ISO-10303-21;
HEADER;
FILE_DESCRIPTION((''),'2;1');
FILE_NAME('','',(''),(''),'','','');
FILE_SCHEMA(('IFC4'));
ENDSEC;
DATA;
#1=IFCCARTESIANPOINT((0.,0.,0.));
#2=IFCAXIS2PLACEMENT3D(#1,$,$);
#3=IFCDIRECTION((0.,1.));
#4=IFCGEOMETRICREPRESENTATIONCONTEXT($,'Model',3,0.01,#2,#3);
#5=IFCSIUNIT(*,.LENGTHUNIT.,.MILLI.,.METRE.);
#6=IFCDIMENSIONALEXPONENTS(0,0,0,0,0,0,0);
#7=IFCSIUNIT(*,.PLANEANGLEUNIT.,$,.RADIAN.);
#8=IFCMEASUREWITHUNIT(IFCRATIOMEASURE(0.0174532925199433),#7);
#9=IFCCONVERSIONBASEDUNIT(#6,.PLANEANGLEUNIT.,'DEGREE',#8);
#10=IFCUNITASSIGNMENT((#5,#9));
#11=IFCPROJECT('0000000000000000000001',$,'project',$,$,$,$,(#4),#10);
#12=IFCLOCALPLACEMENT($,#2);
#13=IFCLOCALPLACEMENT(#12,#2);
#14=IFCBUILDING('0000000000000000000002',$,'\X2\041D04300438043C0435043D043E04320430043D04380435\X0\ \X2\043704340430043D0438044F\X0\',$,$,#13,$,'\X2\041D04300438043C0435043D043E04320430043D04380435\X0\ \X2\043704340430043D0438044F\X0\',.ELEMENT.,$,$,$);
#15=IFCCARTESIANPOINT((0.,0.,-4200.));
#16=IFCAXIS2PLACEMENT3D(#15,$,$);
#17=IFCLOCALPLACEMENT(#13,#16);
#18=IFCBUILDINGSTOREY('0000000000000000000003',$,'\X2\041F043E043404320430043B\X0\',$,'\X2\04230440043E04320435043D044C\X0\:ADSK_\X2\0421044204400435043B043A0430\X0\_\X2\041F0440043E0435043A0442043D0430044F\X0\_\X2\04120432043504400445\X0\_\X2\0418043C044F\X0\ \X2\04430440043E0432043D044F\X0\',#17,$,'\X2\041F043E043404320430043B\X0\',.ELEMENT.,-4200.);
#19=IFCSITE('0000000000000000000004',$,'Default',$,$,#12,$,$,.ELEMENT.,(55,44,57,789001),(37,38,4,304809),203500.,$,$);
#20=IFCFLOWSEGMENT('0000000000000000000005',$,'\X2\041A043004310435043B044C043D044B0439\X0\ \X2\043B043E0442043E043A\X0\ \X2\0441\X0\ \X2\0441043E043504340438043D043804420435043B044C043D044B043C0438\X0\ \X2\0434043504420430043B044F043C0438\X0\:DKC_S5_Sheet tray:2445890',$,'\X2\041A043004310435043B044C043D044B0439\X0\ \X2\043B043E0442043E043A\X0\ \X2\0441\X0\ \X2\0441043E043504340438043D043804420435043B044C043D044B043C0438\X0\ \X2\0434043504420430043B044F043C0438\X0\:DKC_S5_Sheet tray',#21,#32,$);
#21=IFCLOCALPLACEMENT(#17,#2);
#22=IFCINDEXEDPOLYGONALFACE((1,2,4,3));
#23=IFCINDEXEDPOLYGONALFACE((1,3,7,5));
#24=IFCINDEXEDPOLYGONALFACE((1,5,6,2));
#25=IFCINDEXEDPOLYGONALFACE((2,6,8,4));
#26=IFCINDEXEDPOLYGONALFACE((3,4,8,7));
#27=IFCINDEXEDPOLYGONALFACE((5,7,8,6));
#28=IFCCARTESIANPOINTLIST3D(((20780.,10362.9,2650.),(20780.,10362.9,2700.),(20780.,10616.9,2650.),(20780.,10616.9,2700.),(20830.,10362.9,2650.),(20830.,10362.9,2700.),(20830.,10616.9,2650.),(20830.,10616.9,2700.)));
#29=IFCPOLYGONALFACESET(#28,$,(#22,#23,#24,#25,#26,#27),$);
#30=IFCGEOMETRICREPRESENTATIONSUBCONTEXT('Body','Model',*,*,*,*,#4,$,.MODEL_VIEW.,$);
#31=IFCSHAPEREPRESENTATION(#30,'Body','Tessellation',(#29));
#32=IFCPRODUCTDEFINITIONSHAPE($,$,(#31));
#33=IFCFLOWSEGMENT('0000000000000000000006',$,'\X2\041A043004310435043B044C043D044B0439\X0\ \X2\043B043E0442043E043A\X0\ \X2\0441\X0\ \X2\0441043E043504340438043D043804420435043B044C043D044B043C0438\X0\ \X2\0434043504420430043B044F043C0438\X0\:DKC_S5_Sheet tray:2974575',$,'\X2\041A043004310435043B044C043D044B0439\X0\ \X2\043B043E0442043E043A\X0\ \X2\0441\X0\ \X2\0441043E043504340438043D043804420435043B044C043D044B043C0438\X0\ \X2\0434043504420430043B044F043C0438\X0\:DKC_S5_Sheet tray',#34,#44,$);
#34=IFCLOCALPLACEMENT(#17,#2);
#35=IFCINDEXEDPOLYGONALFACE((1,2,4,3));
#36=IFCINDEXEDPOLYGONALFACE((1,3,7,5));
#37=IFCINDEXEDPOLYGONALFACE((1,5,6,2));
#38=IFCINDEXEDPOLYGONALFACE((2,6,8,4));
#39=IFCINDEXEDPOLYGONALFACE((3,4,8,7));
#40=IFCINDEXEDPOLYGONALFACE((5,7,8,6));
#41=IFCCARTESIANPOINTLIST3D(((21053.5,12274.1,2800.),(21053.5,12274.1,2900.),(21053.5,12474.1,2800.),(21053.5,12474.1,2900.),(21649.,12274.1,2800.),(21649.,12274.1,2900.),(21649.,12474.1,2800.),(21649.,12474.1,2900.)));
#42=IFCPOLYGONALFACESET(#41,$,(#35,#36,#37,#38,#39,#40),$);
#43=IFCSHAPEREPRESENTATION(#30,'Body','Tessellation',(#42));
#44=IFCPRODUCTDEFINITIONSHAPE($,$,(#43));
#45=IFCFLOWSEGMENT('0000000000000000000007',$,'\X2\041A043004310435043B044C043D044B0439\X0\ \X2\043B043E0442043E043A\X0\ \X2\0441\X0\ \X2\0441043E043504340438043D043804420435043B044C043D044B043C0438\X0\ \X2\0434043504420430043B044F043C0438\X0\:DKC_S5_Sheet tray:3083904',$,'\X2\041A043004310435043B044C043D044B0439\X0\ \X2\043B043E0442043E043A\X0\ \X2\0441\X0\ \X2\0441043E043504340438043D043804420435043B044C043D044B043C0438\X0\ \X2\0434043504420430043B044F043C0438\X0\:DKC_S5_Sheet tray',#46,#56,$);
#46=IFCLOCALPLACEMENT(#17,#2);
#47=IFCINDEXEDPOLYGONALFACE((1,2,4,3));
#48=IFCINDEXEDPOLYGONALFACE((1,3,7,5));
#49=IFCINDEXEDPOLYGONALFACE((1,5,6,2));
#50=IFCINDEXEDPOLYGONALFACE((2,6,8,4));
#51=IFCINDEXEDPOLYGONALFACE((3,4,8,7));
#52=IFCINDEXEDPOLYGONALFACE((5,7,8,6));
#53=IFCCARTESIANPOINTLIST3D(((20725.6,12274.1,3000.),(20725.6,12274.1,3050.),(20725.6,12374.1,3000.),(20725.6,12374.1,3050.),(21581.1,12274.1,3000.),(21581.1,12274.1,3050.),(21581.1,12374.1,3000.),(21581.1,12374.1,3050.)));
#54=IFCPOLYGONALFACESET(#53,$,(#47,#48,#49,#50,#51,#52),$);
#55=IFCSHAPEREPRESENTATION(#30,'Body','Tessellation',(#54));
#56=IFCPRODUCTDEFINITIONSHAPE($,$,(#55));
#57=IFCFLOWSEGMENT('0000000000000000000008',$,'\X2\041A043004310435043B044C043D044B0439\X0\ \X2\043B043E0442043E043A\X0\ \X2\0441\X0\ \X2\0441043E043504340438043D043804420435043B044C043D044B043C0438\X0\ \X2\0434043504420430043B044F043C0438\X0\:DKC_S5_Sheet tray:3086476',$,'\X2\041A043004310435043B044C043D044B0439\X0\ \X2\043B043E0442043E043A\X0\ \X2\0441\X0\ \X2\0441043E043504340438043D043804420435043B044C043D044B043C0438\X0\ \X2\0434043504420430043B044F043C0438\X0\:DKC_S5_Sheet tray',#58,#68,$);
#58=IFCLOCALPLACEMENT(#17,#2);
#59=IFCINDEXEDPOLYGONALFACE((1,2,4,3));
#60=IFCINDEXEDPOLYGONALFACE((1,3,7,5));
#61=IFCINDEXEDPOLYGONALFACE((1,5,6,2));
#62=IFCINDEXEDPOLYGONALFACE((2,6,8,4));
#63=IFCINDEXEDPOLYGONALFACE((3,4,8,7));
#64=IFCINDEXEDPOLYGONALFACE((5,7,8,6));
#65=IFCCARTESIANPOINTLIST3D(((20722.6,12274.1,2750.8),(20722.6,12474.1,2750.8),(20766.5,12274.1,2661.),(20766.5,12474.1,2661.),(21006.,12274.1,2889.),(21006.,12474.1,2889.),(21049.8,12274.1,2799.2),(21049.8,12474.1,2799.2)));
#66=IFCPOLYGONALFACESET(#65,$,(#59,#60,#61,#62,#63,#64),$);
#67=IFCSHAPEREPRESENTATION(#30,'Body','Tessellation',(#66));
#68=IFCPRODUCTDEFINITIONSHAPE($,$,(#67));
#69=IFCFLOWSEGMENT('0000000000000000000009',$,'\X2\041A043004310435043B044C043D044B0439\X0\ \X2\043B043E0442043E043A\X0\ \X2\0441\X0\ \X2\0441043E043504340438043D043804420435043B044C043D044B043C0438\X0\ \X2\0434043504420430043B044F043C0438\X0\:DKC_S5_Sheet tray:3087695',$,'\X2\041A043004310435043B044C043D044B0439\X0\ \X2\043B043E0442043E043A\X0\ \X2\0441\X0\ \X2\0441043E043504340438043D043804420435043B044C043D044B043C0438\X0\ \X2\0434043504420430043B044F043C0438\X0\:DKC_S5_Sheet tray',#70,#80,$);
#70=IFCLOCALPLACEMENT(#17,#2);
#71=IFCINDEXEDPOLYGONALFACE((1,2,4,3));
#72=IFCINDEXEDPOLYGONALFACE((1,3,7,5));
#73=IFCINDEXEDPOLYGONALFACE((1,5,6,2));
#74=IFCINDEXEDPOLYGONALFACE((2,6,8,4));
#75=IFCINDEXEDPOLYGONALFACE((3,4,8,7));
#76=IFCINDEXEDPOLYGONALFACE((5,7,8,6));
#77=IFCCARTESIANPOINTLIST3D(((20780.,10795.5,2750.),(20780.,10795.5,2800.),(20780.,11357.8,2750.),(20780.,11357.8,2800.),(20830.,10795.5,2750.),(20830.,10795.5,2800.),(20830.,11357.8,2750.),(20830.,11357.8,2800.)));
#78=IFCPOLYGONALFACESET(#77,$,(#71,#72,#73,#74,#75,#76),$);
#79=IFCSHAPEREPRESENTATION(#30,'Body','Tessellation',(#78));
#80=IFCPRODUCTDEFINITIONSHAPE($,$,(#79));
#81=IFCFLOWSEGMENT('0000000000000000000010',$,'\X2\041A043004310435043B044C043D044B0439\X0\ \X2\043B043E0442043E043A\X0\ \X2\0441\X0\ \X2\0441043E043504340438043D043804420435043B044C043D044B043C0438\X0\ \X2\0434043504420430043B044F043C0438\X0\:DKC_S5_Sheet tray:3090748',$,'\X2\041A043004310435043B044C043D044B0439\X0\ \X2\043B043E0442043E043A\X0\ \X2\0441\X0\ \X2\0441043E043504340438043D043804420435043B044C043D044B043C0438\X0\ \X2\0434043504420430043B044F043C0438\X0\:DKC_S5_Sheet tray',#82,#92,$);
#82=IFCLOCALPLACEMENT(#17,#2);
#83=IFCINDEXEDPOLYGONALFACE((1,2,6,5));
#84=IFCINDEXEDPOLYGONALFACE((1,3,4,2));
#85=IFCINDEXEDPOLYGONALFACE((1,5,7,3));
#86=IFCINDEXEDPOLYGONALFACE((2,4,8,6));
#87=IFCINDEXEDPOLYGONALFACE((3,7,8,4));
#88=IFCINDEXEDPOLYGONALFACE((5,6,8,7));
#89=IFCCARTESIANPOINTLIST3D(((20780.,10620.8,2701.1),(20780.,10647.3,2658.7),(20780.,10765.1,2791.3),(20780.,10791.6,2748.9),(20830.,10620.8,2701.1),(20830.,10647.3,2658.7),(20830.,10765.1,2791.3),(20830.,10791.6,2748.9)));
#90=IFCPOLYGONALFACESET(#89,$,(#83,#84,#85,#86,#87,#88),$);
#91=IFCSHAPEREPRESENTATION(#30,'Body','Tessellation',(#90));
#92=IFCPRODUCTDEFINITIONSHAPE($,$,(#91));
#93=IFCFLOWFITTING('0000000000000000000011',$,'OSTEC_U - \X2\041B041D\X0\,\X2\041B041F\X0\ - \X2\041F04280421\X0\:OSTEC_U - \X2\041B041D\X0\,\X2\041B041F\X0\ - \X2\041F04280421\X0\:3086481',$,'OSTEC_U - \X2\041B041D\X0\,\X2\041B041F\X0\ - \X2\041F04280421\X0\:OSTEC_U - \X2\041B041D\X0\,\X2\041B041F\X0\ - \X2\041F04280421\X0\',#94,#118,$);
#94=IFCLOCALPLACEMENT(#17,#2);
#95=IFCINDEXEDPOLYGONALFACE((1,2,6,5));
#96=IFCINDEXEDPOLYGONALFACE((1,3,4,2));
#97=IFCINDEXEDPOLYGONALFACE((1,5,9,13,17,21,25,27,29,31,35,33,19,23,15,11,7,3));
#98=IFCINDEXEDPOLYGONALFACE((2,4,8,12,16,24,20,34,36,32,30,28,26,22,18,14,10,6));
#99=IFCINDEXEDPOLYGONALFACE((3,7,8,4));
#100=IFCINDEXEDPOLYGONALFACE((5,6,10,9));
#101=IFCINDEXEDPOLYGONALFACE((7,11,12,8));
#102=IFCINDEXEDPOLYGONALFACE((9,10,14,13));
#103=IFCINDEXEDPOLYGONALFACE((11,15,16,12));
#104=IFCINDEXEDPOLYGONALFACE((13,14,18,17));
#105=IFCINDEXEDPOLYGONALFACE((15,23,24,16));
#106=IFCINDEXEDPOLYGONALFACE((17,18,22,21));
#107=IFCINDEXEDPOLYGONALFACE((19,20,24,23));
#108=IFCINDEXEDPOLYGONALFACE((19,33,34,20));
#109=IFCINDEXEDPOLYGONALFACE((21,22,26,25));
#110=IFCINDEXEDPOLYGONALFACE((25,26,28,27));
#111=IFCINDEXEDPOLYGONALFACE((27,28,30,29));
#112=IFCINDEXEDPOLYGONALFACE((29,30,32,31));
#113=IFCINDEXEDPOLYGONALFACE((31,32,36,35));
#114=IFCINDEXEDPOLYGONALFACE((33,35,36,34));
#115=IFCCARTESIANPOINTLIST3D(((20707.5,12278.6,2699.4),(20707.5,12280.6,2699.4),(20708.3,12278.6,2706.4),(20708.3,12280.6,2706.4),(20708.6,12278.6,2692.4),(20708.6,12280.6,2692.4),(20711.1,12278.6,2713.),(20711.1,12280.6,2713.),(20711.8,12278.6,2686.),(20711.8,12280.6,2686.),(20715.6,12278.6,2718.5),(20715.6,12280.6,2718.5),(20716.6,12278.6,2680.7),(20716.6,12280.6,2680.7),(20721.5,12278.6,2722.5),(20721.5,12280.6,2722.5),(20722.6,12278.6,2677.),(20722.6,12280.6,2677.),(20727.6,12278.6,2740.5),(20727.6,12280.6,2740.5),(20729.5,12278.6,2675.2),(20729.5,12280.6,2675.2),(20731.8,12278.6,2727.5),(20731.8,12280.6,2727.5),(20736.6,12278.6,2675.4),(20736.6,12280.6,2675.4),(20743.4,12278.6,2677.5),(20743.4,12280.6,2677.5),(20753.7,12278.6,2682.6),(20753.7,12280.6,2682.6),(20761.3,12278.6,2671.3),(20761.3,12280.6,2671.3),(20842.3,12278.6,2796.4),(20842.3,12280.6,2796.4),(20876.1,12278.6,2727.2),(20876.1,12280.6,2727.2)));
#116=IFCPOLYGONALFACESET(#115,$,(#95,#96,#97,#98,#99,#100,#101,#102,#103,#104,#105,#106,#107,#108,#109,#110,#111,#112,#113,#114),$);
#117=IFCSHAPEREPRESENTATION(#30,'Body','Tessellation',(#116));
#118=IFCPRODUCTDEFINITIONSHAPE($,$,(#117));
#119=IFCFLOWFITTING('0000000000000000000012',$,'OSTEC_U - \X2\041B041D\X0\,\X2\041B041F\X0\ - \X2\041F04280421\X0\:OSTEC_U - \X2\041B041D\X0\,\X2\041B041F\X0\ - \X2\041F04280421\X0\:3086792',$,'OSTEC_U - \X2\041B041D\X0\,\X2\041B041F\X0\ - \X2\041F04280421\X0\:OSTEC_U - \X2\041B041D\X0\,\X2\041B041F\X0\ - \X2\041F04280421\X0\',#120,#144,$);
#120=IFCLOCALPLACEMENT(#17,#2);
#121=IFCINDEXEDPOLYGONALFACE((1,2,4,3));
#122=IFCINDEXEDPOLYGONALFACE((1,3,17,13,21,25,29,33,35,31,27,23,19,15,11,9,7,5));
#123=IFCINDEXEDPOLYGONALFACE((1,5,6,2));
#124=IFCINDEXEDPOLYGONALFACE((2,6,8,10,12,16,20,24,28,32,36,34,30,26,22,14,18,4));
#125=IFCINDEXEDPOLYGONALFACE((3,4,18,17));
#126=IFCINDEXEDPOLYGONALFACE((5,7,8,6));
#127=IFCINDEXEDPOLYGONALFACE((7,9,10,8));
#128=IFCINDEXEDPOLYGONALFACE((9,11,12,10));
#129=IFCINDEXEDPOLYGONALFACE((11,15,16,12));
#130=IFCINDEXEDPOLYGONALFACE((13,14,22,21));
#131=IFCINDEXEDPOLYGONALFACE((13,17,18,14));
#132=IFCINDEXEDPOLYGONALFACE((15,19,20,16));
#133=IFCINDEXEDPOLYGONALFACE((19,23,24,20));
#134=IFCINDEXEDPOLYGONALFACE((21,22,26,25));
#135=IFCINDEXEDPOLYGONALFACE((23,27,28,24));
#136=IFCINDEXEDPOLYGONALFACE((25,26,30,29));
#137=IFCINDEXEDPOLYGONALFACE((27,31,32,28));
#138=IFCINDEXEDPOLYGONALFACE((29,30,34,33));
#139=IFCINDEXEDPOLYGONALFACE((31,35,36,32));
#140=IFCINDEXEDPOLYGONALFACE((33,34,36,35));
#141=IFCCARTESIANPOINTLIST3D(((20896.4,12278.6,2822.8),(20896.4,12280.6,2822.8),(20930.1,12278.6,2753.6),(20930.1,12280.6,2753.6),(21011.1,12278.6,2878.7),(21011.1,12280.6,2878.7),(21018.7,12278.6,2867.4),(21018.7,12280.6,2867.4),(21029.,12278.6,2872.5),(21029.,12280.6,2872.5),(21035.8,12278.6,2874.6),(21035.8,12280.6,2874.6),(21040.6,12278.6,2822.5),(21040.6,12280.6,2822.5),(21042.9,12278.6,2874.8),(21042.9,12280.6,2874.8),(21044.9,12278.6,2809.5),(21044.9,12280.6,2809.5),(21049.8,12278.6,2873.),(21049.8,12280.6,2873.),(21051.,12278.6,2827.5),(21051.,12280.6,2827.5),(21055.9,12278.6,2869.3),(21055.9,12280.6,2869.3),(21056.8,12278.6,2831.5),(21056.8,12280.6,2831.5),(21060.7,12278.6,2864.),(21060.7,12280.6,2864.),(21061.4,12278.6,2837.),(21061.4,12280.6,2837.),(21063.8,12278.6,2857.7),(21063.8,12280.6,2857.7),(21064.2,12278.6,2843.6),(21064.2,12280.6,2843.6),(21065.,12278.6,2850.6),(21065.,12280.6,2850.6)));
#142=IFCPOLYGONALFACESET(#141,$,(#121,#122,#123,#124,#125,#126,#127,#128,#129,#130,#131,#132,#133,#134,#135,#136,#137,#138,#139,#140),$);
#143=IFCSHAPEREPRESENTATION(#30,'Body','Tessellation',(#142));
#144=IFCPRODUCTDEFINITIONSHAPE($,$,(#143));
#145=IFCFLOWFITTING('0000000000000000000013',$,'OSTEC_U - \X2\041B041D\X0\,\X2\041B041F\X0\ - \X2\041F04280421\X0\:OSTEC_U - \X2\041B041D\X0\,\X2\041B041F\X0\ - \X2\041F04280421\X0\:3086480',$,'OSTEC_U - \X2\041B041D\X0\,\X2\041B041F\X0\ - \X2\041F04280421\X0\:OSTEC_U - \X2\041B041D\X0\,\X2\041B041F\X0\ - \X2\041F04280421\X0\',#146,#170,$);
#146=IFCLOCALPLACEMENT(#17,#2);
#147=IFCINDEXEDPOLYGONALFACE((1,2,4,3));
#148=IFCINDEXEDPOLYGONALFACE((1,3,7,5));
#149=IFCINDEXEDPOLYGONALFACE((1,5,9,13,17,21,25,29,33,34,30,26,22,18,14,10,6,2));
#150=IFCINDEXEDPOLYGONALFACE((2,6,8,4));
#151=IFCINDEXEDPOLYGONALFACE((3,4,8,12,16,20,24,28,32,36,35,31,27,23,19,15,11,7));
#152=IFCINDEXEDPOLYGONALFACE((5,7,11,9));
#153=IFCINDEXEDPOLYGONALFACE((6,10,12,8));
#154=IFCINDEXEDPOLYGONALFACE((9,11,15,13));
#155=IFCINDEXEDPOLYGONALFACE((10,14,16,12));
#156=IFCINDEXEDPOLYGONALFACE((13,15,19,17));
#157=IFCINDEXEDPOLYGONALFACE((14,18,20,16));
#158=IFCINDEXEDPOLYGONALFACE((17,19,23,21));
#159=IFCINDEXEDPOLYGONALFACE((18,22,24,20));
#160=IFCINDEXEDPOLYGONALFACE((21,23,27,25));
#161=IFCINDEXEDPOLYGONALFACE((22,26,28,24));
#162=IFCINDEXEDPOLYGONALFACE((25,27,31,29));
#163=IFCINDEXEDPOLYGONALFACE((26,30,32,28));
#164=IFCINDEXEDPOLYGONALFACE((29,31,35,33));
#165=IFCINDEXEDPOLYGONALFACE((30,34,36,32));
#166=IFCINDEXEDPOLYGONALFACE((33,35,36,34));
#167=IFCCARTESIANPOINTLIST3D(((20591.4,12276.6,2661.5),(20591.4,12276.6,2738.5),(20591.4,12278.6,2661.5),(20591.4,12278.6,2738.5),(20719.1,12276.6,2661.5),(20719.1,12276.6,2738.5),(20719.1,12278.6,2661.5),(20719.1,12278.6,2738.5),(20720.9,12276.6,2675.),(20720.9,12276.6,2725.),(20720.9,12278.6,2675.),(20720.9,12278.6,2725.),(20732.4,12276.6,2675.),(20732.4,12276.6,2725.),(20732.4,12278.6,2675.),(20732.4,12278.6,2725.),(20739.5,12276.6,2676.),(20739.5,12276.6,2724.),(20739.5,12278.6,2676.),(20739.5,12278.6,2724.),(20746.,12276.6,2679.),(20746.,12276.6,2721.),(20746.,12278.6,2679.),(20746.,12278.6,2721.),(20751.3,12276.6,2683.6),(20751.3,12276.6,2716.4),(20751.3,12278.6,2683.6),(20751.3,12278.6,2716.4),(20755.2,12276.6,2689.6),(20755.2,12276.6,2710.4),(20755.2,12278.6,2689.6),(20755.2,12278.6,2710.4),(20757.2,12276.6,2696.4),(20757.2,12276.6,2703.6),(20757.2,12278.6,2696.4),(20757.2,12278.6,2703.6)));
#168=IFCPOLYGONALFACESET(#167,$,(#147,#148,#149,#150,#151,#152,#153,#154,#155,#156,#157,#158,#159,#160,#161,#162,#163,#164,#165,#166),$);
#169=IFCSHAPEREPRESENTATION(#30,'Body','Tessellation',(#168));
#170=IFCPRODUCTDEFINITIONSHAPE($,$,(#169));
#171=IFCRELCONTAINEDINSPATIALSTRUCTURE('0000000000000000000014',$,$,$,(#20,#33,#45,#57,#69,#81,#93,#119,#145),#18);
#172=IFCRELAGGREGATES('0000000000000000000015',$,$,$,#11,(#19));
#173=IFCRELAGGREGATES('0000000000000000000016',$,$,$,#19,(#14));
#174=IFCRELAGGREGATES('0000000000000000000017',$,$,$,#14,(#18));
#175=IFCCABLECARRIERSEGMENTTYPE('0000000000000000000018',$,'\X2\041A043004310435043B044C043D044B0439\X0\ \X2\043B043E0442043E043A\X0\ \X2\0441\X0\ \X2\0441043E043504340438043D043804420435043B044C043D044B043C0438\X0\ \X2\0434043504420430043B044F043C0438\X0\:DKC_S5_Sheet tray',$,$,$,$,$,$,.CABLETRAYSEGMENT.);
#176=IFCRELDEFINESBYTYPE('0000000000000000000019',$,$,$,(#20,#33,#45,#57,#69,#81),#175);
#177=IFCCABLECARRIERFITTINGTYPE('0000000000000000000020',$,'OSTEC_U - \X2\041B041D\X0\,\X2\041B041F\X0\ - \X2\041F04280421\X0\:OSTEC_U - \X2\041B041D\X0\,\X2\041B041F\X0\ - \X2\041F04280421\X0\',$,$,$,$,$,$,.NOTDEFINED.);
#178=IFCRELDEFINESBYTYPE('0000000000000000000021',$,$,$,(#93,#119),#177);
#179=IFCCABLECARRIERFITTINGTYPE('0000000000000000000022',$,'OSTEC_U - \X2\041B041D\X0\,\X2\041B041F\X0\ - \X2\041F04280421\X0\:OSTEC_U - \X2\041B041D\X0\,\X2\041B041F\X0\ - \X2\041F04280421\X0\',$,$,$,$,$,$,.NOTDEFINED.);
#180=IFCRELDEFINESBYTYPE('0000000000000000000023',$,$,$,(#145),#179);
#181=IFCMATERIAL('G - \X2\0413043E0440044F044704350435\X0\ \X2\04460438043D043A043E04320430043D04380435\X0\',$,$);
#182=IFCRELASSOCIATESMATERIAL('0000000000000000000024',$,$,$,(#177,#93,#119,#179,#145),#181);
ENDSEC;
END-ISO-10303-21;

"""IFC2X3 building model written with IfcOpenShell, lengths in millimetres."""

from ifc_helpers import new_model, entity, si_unit, converted_unit, direction, frame, frame_2d, origin, origin_2d_with_axis, place, context, subcontext, project, spatial, polyline, circle_curve, parameter, trimmed, segment, composite_curve, rectangle, outline, extrude, source, transform, mapped, material, type_object, type_shapes, element, save


model = new_model("IFC2X3")

# Units and contexts
model_context = context("Model", 3, precision=0.01, world=origin(), true_north=direction((0.0, 1.0)))
body_context = subcontext(model_context, "Body", "Model", "MODEL_VIEW")
ifc_project = project(units=[si_unit("LENGTHUNIT", "METRE", prefix="MILLI"), converted_unit("PLANEANGLEUNIT", "DEGREE", entity("IfcRatioMeasure", 0.0174532925199433), si_unit("PLANEANGLEUNIT", "RADIAN"), dimensions=[0, 0, 0, 0, 0, 0, 0])], contexts=[model_context])

# Site, building, storey
site_placement = place(None, origin())
site = spatial("IfcSite", under=ifc_project, at=site_placement, Name="Default", CompositionType="ELEMENT", RefLatitude=(55, 44, 57, 789001), RefLongitude=(37, 38, 4, 304809), RefElevation=203500.0)
building_placement = place(site_placement, origin())
building = spatial("IfcBuilding", under=site, at=building_placement, Name="Наименование здания", LongName="Наименование здания", CompositionType="ELEMENT")
storey_placement = place(building_placement, frame((0.0, 0.0, -4200.0)))
storey = spatial("IfcBuildingStorey", under=building, at=storey_placement, Name="Подвал", ObjectType="Уровень:ADSK_Стрелка_Проектная_Вверх_Имя уровня", LongName="Подвал", CompositionType="ELEMENT", Elevation=-4200.0)

# Flow segments
cable_carrier_segment_type = type_object("IfcCableCarrierSegmentType", Name="Кабельный лоток с соединительными деталями:DKC_S5_Sheet tray", PredefinedType="CABLETRAYSEGMENT")
flow_segment_1_placement = place(storey_placement, frame((20780.0, 10362.9, 2650.0)))
element("IfcFlowSegment", 1, at=flow_segment_1_placement, inside=storey, type_object=cable_carrier_segment_type, Name="Кабельный лоток с соединительными деталями:DKC_S5_Sheet tray:2445890", ObjectType="Кабельный лоток с соединительными деталями:DKC_S5_Sheet tray", context=body_context, shape_type="SweptSolid", body=[
    extrude(rectangle(XDim=254.0, YDim=50.0, at=origin_2d_with_axis()), frame((25.0, 127.0, 0.0), z_axis=(0.0, 0.0, 1.0), x_axis=(0.0, 1.0, 0.0)), (0.0, 0.0, 1.0), 50.0),
])
flow_segment_2_placement = place(storey_placement, frame((21053.5, 12274.1, 2800.0)))
element("IfcFlowSegment", 2, at=flow_segment_2_placement, inside=storey, type_object=cable_carrier_segment_type, Name="Кабельный лоток с соединительными деталями:DKC_S5_Sheet tray:2974575", ObjectType="Кабельный лоток с соединительными деталями:DKC_S5_Sheet tray", context=body_context, shape_type="SweptSolid", body=[
    extrude(rectangle(XDim=595.5, YDim=200.0, at=origin_2d_with_axis()), frame((297.8, 100.0, 0.0), z_axis=(-0.000053, 0.000015, 1.0), x_axis=(-1.0, 0.0, -0.000053)), (0.0, 0.0, 1.0), 100.0),
])
flow_segment_3_placement = place(storey_placement, frame((20725.6, 12274.1, 3000.0)))
element("IfcFlowSegment", 3, at=flow_segment_3_placement, inside=storey, type_object=cable_carrier_segment_type, Name="Кабельный лоток с соединительными деталями:DKC_S5_Sheet tray:3083904", ObjectType="Кабельный лоток с соединительными деталями:DKC_S5_Sheet tray", context=body_context, shape_type="SweptSolid", body=[
    extrude(rectangle(XDim=855.6, YDim=100.0, at=origin_2d_with_axis()), frame((427.8, 50.0, 0.0), z_axis=(0.0, 0.0, 1.0), x_axis=(-1.0, 0.0, 0.0)), (0.0, 0.0, 1.0), 50.0),
])
flow_segment_4_placement = place(storey_placement, frame((20722.6, 12274.1, 2661.0)))
element("IfcFlowSegment", 4, at=flow_segment_4_placement, inside=storey, type_object=cable_carrier_segment_type, Name="Кабельный лоток с соединительными деталями:DKC_S5_Sheet tray:3086476", ObjectType="Кабельный лоток с соединительными деталями:DKC_S5_Sheet tray", context=body_context, shape_type="SweptSolid", body=[
    extrude(rectangle(XDim=100.0, YDim=200.0, at=origin_2d_with_axis()), frame((21.9, 100.0, 44.9), z_axis=(0.898793, 0.0, 0.438374), x_axis=(-0.438374, 0.0, 0.898793)), (0.0, 0.0, 1.0), 315.2),
])
flow_segment_5_placement = place(storey_placement, frame((20780.0, 10795.5, 2750.0)))
element("IfcFlowSegment", 5, at=flow_segment_5_placement, inside=storey, type_object=cable_carrier_segment_type, Name="Кабельный лоток с соединительными деталями:DKC_S5_Sheet tray:3087695", ObjectType="Кабельный лоток с соединительными деталями:DKC_S5_Sheet tray", context=body_context, shape_type="SweptSolid", body=[
    extrude(rectangle(XDim=562.3, YDim=50.0, at=origin_2d_with_axis()), frame((25.0, 281.2, 0.0), z_axis=(0.0, 0.0, 1.0), x_axis=(0.0, -1.0, 0.0)), (0.0, 0.0, 1.0), 50.0),
])
flow_segment_6_placement = place(storey_placement, frame((20780.0, 10620.8, 2658.7)))
element("IfcFlowSegment", 6, at=flow_segment_6_placement, inside=storey, type_object=cable_carrier_segment_type, Name="Кабельный лоток с соединительными деталями:DKC_S5_Sheet tray:3090748", ObjectType="Кабельный лоток с соединительными деталями:DKC_S5_Sheet tray", context=body_context, shape_type="SweptSolid", body=[
    extrude(rectangle(XDim=50.0, YDim=50.0, at=frame_2d((0.0, 0.0), x_axis=(0.0, 1.0))), frame((25.0, 13.2, 21.2), z_axis=(0.0, 0.848048, 0.529919), x_axis=(-1.0, 0.0, 0.0)), (0.0, 0.0, 1.0), 170.1),
])

# Flow fittings
ifc_material_1 = material(Name="G - Горячее цинкование")
cable_carrier_fitting_type_1 = type_object("IfcCableCarrierFittingType", Name="OSTEC_U - ЛН,ЛП - ПШС:OSTEC_U - ЛН,ЛП - ПШС", PredefinedType="NOTDEFINED", material=ifc_material_1)
shared_shape_1 = source(origin(), body_context, "Body", "SweptSolid", [
    extrude(outline(composite_curve([segment(trimmed(circle_curve(frame_2d((-41.5, 0.0), x_axis=(1.0, 0.0)), 25.0), [parameter(90.0)], [parameter(270.0)], True, "PARAMETER"), True, "CONTINUOUS"), segment(polyline([(-41.5, -25.0), (-30.0, -25.0)]), True, "CONTINUOUS"), segment(polyline([(-30.0, -25.0), (-28.1, -38.5)]), True, "CONTINUOUS"), segment(polyline([(-28.1, -38.5), (99.5, -38.5)]), True, "CONTINUOUS"), segment(polyline([(99.5, -38.5), (99.5, 38.5)]), True, "CONTINUOUS"), segment(polyline([(99.5, 38.5), (-28.1, 38.5)]), True, "CONTINUOUS"), segment(polyline([(-28.1, 38.5), (-30.0, 25.0)]), True, "CONTINUOUS"), segment(polyline([(-30.0, 25.0), (-41.5, 25.0)]), True, "CONTINUOUS")], self_intersect=False)), frame((41.5, 0.0, 0.0), z_axis=(0.0, 0.0, -1.0), x_axis=(1.0, 0.0, 0.0)), (0.0, 0.0, -1.0), 2.0),
])
type_shapes(cable_carrier_fitting_type_1, [shared_shape_1])
for number, where, z_axis, x_axis, name in (
    (7, (20732.5, 12280.6, 2700.0), (0.0, -1.0, 0.0), (0.898794, 0.0, 0.438371), "OSTEC_U - ЛН,ЛП - ПШС:OSTEC_U - ЛН,ЛП - ПШС:3086481"),
    (8, (21040.0, 12280.6, 2850.0), (0.0, -1.0, 0.0), (-0.898793, 0.0, -0.438374), "OSTEC_U - ЛН,ЛП - ПШС:OSTEC_U - ЛН,ЛП - ПШС:3086792"),
):
    element("IfcFlowFitting", number, at=place(storey_placement, frame(where, z_axis=z_axis, x_axis=x_axis)), inside=storey, type_object=cable_carrier_fitting_type_1, material=ifc_material_1, Name=name, ObjectType="OSTEC_U - ЛН,ЛП - ПШС:OSTEC_U - ЛН,ЛП - ПШС", context=body_context, shape_type="MappedRepresentation", body=[
        mapped(shared_shape_1, transform((0.0, 0.0, 0.0), scale=1.0)),
    ])
cable_carrier_fitting_type_2 = type_object("IfcCableCarrierFittingType", Name="OSTEC_U - ЛН,ЛП - ПШС:OSTEC_U - ЛН,ЛП - ПШС", PredefinedType="NOTDEFINED", material=ifc_material_1)
shared_shape_2 = source(origin(), body_context, "Body", "SweptSolid", [
    extrude(outline(composite_curve([segment(trimmed(circle_curve(frame_2d((-41.5, 0.0), x_axis=(1.0, 0.0)), 25.0), [parameter(90.0)], [parameter(270.0)], True, "PARAMETER"), True, "CONTINUOUS"), segment(polyline([(-41.5, -25.0), (-30.0, -25.0)]), True, "CONTINUOUS"), segment(polyline([(-30.0, -25.0), (-28.1, -38.5)]), True, "CONTINUOUS"), segment(polyline([(-28.1, -38.5), (99.5, -38.5)]), True, "CONTINUOUS"), segment(polyline([(99.5, -38.5), (99.5, 38.5)]), True, "CONTINUOUS"), segment(polyline([(99.5, 38.5), (-28.1, 38.5)]), True, "CONTINUOUS"), segment(polyline([(-28.1, 38.5), (-30.0, 25.0)]), True, "CONTINUOUS"), segment(polyline([(-30.0, 25.0), (-41.5, 25.0)]), True, "CONTINUOUS")], self_intersect=False)), frame((41.5, 0.0, 0.0)), (0.0, 0.0, 1.0), 2.0),
])
type_shapes(cable_carrier_fitting_type_2, [shared_shape_2])
for number, where, z_axis, x_axis, name in (
    (9, (20732.5, 12278.6, 2700.0), (0.0, -1.0, 0.0), (-1.0, 0.0, 0.0), "OSTEC_U - ЛН,ЛП - ПШС:OSTEC_U - ЛН,ЛП - ПШС:3086480"),
):
    element("IfcFlowFitting", number, at=place(storey_placement, frame(where, z_axis=z_axis, x_axis=x_axis)), inside=storey, type_object=cable_carrier_fitting_type_2, material=ifc_material_1, Name=name, ObjectType="OSTEC_U - ЛН,ЛП - ПШС:OSTEC_U - ЛН,ЛП - ПШС", context=body_context, shape_type="MappedRepresentation", body=[
        mapped(shared_shape_2, transform((0.0, 0.0, 0.0), scale=1.0)),
    ])

save(model, "model.ifc")
